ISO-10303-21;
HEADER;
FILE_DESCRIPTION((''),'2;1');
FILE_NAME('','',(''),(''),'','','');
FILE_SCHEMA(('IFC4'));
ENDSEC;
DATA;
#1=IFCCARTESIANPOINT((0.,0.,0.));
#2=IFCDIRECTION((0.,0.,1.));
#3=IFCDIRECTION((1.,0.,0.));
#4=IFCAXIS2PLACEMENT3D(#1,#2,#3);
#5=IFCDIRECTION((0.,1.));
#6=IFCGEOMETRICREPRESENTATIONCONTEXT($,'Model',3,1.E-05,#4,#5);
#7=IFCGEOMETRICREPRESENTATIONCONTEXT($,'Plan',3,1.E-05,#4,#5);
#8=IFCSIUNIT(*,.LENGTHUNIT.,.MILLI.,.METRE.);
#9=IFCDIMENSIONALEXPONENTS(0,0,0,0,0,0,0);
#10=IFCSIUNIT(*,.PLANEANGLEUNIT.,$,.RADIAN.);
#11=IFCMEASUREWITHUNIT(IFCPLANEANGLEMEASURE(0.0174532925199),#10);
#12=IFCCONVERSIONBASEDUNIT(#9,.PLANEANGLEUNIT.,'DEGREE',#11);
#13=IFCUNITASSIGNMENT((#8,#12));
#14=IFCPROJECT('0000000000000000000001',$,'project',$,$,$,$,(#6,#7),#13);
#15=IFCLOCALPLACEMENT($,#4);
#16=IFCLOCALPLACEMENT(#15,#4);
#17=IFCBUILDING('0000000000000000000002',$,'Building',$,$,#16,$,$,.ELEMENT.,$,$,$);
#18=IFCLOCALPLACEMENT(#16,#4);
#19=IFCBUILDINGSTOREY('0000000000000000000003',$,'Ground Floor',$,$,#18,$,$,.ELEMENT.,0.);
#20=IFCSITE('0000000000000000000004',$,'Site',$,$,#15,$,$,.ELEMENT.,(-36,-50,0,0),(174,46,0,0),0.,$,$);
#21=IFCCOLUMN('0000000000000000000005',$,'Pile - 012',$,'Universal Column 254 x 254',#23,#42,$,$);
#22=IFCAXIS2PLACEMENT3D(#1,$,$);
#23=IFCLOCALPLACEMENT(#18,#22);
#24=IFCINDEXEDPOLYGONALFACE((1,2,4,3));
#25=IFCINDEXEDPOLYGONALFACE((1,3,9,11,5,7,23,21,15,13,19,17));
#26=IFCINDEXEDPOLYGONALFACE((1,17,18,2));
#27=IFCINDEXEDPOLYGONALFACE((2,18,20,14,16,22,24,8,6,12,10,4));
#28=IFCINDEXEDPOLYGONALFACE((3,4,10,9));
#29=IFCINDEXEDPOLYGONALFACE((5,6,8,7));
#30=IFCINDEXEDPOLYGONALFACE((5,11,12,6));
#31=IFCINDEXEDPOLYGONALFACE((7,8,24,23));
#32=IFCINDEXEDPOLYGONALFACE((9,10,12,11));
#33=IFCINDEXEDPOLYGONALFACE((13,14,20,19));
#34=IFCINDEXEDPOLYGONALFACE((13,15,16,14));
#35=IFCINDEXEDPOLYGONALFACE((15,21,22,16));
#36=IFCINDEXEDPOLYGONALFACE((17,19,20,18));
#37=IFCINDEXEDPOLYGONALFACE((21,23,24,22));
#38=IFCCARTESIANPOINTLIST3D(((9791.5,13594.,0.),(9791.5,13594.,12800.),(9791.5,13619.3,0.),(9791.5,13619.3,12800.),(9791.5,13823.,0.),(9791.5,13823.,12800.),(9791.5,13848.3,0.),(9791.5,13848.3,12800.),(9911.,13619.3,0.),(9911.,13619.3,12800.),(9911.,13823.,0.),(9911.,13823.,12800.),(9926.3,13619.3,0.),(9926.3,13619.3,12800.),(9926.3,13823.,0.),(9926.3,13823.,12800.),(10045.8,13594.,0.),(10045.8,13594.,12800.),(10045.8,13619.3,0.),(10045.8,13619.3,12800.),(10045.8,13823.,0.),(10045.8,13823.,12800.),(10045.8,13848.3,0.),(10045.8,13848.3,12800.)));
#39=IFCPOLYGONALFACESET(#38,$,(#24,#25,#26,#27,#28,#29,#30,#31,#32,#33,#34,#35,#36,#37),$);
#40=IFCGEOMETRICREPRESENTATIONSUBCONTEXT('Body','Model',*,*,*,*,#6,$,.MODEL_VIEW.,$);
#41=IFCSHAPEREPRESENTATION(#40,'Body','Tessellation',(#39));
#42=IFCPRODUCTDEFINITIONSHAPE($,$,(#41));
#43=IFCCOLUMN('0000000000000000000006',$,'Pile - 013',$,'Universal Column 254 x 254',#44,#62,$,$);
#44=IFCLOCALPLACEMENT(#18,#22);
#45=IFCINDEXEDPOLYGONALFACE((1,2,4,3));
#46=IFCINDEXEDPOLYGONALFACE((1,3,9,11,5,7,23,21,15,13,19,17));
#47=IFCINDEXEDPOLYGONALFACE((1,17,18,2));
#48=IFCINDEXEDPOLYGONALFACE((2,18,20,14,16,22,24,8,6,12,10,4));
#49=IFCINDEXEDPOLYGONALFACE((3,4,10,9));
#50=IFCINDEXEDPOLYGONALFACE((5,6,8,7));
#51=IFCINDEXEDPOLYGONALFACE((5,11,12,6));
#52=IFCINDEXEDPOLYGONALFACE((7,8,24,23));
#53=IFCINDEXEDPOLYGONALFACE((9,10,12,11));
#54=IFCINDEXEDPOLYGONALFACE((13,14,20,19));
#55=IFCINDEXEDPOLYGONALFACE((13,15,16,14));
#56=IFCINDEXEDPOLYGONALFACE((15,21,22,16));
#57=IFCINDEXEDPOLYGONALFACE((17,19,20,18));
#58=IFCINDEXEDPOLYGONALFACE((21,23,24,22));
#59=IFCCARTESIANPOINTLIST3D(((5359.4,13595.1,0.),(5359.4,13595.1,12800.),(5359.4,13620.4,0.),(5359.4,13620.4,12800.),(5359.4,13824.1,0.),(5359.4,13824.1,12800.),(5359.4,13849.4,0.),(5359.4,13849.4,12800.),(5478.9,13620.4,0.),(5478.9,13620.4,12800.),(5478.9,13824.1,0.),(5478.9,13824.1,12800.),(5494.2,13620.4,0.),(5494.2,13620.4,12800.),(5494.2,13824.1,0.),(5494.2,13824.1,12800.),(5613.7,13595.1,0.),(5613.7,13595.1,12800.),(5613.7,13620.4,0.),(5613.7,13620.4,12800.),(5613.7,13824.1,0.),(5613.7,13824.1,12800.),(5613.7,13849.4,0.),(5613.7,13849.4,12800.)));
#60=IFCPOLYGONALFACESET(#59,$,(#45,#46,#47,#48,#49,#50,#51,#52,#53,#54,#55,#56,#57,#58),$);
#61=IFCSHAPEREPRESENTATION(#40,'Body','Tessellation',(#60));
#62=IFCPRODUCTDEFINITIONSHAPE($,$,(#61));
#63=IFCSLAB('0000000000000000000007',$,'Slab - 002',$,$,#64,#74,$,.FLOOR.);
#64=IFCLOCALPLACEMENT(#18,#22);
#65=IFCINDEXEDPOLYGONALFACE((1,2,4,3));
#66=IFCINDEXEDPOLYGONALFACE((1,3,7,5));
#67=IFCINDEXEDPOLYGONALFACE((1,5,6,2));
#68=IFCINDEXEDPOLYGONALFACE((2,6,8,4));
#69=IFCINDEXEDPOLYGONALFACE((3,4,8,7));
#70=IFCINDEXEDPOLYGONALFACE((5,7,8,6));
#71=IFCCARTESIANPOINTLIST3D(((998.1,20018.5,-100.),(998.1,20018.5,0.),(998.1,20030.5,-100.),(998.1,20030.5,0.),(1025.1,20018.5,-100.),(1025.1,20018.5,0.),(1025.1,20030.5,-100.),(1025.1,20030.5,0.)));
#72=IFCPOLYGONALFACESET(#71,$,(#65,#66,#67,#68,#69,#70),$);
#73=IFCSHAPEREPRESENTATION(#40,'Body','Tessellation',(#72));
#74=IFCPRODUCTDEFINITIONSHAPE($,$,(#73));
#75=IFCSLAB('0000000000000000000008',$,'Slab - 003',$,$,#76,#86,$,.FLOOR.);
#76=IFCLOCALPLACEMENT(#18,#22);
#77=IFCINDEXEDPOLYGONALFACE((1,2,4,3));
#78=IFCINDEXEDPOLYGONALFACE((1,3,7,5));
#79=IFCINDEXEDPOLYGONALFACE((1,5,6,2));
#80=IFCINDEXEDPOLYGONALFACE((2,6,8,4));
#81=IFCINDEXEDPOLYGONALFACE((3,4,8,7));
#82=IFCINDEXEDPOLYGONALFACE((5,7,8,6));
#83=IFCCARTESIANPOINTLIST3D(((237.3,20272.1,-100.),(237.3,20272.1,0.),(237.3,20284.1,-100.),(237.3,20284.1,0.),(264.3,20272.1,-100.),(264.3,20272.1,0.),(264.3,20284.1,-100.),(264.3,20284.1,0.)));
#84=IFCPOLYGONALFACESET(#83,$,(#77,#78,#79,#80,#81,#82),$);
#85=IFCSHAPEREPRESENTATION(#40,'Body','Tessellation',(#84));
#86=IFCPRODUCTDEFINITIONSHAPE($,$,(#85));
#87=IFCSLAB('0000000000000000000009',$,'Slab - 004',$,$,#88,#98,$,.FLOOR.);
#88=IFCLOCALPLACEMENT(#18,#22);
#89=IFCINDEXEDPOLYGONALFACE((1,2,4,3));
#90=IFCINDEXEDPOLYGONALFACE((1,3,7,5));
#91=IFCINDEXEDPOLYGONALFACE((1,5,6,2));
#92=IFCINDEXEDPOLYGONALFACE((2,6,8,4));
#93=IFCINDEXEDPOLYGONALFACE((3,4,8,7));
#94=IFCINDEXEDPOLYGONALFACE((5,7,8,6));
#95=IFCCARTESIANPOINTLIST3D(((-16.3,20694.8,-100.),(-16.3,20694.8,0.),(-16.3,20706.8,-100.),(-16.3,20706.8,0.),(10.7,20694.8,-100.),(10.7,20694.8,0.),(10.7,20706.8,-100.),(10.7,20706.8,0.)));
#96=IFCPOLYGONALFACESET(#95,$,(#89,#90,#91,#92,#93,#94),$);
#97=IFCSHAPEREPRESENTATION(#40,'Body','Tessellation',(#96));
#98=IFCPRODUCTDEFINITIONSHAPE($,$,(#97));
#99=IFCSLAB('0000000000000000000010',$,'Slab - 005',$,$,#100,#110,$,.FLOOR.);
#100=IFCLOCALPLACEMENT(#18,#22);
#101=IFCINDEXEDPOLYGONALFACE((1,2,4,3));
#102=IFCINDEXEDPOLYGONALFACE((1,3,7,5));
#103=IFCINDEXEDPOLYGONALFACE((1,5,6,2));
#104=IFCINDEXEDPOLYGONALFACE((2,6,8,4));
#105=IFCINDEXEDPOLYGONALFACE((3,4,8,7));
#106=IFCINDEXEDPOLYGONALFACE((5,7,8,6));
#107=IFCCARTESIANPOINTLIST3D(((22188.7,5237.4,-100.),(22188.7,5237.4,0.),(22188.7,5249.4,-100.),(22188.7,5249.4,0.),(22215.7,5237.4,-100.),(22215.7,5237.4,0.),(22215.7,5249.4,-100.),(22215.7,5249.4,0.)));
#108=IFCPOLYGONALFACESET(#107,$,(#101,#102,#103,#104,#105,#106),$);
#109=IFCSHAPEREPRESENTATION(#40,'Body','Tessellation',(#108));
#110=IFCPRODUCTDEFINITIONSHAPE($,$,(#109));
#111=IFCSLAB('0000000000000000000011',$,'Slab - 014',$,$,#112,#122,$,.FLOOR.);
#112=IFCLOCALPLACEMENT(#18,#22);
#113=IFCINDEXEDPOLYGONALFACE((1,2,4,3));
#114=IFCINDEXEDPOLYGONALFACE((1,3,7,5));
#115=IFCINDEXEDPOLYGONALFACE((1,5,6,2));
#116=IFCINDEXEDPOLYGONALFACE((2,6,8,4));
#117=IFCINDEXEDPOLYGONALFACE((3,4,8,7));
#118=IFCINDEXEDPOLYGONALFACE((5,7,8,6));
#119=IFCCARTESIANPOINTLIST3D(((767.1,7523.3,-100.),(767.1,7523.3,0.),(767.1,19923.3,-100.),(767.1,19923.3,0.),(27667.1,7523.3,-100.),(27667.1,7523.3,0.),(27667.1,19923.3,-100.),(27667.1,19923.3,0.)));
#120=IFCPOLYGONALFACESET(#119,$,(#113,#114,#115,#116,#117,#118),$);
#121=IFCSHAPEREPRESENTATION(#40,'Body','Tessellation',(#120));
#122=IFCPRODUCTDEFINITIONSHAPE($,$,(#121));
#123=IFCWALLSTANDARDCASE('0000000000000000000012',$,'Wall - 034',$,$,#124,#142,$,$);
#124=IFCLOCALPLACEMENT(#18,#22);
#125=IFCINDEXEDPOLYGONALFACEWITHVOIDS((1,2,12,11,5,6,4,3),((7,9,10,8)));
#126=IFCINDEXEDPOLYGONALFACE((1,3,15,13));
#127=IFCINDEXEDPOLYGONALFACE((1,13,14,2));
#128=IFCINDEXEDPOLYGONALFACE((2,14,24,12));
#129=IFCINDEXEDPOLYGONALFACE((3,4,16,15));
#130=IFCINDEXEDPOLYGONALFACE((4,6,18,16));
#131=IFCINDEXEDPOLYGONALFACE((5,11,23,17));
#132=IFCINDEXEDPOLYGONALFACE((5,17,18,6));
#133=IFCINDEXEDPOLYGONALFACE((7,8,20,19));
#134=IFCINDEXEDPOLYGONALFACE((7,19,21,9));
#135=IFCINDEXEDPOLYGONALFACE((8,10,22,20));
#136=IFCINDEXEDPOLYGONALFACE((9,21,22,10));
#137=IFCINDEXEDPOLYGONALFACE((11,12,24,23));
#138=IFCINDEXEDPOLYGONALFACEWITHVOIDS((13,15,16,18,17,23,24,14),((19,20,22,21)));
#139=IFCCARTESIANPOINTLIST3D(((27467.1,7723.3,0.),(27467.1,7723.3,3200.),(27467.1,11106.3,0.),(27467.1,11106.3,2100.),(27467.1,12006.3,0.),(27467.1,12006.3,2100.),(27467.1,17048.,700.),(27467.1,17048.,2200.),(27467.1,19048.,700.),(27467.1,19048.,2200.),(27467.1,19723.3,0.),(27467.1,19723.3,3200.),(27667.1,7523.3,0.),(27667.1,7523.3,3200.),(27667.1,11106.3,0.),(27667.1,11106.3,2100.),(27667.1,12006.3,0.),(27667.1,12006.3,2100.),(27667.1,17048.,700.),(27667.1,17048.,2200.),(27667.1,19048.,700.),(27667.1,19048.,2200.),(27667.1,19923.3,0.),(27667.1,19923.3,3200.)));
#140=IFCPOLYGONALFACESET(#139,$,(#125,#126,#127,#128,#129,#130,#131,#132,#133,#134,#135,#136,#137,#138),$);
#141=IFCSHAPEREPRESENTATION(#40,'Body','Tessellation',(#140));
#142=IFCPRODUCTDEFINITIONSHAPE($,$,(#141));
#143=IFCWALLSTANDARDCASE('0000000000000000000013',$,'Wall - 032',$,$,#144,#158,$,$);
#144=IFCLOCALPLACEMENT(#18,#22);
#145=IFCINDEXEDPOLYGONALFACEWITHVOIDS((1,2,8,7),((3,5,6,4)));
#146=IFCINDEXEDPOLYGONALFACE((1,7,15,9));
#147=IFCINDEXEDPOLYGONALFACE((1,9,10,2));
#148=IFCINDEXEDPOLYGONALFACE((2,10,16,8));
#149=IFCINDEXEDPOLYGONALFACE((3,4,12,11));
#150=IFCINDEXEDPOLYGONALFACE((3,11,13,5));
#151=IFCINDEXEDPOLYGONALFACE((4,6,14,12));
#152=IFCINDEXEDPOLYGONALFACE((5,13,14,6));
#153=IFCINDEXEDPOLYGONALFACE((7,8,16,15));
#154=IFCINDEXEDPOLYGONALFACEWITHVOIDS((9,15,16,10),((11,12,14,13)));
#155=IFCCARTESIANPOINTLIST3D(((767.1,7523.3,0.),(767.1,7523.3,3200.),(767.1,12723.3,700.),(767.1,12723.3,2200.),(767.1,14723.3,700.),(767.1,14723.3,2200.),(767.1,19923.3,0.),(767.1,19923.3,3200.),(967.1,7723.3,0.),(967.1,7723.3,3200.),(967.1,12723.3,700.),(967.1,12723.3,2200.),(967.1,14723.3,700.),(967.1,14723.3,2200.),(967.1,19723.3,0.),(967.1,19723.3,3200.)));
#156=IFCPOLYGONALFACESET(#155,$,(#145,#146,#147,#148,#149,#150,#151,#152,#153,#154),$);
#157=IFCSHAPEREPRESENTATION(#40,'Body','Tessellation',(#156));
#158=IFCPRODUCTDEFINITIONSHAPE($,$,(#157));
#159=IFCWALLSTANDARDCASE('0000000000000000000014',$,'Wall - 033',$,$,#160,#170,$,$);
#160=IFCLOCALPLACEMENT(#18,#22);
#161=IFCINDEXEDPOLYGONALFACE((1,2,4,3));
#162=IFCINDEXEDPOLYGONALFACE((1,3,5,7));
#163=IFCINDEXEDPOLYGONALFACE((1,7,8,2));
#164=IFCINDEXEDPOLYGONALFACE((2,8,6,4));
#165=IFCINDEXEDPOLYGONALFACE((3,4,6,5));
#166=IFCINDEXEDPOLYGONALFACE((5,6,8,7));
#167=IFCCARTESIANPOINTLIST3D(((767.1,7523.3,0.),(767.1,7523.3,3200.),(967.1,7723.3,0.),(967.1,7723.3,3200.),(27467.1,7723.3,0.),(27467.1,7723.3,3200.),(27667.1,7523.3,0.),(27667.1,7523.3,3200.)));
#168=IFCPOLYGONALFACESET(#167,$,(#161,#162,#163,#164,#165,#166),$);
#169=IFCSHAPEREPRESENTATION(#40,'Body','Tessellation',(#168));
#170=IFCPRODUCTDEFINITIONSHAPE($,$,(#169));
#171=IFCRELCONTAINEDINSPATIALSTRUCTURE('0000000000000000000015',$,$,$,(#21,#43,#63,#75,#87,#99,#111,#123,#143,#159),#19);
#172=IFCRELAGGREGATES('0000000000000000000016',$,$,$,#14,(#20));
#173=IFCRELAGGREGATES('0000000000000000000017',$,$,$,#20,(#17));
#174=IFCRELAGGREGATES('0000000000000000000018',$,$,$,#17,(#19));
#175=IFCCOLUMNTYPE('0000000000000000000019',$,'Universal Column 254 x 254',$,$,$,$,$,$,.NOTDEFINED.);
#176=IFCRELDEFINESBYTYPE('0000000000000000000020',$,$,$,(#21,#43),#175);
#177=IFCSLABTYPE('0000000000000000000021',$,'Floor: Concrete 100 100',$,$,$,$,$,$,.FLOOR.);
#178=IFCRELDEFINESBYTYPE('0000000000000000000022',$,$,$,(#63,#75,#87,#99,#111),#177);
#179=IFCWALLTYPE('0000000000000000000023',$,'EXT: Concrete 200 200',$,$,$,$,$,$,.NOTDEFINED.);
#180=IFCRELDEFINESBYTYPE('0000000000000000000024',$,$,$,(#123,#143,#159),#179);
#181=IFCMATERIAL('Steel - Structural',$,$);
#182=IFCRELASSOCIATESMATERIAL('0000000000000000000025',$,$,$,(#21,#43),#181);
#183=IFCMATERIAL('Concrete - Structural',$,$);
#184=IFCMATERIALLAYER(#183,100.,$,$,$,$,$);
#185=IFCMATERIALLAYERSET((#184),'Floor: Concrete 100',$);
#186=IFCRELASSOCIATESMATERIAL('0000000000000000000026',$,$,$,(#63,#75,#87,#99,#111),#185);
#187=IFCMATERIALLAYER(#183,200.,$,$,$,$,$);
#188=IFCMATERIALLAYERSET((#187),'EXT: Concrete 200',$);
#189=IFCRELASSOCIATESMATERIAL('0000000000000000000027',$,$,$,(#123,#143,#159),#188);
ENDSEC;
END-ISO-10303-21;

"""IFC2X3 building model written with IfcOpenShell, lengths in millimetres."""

from ifc_helpers import new_model, entity, si_unit, converted_unit, direction, frame, origin_with_axes, origin_2d_with_axis, place, context, subcontext, project, spatial, polyline, rectangle, outline, extrude, material, layer, layer_set, layer_usage, type_object, element, save


model = new_model("IFC2X3")

# Units and contexts
model_context = context("Model", 3, precision=1e-05, world=origin_with_axes(), true_north=direction((0.0, 1.0)))
plan_context = context("Plan", 3, precision=1e-05, world=origin_with_axes(), true_north=direction((0.0, 1.0)))
body_context = subcontext(model_context, "Body", "Model", "MODEL_VIEW")
ifc_project = project(units=[si_unit("LENGTHUNIT", "METRE", prefix="MILLI"), converted_unit("PLANEANGLEUNIT", "DEGREE", entity("IfcPlaneAngleMeasure", 0.0174532925199), si_unit("PLANEANGLEUNIT", "RADIAN"), dimensions=[0, 0, 0, 0, 0, 0, 0])], contexts=[model_context, plan_context])

# Site, building, storey
site_placement = place(None, origin_with_axes())
site = spatial("IfcSite", under=ifc_project, at=site_placement, Name="Site", CompositionType="ELEMENT", RefLatitude=(-36, -50, 0, 0), RefLongitude=(174, 46, 0, 0), RefElevation=0.0)
building_placement = place(site_placement, origin_with_axes())
building = spatial("IfcBuilding", under=site, at=building_placement, Name="Building", CompositionType="ELEMENT")
storey_placement = place(building_placement, origin_with_axes())
storey = spatial("IfcBuildingStorey", under=building, at=storey_placement, Name="Ground Floor", CompositionType="ELEMENT", Elevation=0.0)

# Columns
ifc_material_1 = material(Name="Steel - Structural")
column_type = type_object("IfcColumnType", Name="Universal Column 254 x 254", PredefinedType="NOTDEFINED")
for number, where, z_axis, x_axis, name in (
    (1, (9918.6, 13721.1, 0.0), (0.0, 0.0, 1.0), (1.0, 0.0, 0.0), "Pile - 012"),
    (2, (5486.6, 13722.3, 0.0), (0.0, 0.0, 1.0), (1.0, 0.0, 0.0), "Pile - 013"),
):
    element("IfcColumn", number, at=place(storey_placement, frame(where, z_axis=z_axis, x_axis=x_axis)), inside=storey, type_object=column_type, material=ifc_material_1, Name=name, ObjectType="Universal Column 254 x 254", context=body_context, shape_type="SweptSolid", body=[
        extrude(outline(polyline([(-127.2, -127.2), (127.2, -127.2), (127.2, -101.8), (7.7, -101.8), (7.7, 101.8), (127.2, 101.8), (127.2, 127.2), (-127.2, 127.2), (-127.2, 101.8), (-7.7, 101.8), (-7.7, -101.8), (-127.2, -101.8), (-127.2, -127.2)])), origin_with_axes(), (0.0, 0.0, 1.0), 12800.0),
    ])

# Slabs
ifc_material_2 = material(Name="Concrete - Structural")
ifc_layer_1 = layer(ifc_material_2, 100.0)
ifc_layer_set_1 = layer_set([ifc_layer_1], Name="Floor: Concrete 100")
ifc_layer_usage_1 = layer_usage(ifc_layer_set_1, "AXIS3", "NEGATIVE", 100.0)
slab_type = type_object("IfcSlabType", Name="Floor: Concrete 100 100", PredefinedType="FLOOR")
slab_1_placement = place(storey_placement, frame((998.1, 20030.5, 0.0), z_axis=(0.0, 0.0, 1.0), x_axis=(1.0, 0.0, 0.0)))
element("IfcSlab", 3, at=slab_1_placement, inside=storey, type_object=slab_type, material=ifc_layer_usage_1, Name="Slab - 002", PredefinedType="FLOOR", context=body_context, shape_type="SweptSolid", body=[
    extrude(outline(polyline([(0.0, 0.0), (0.0, -12.0), (27.0, -12.0), (27.0, 0.0), (0.0, 0.0)])), frame((0.0, 0.0, -100.0), z_axis=(0.0, 0.0, 1.0), x_axis=(1.0, 0.0, 0.0)), (0.0, 0.0, 1.0), 100.0),
])
ifc_layer_usage_2 = layer_usage(ifc_layer_set_1, "AXIS3", "NEGATIVE", 100.0)
slab_2_placement = place(storey_placement, frame((237.3, 20284.1, 0.0), z_axis=(0.0, 0.0, 1.0), x_axis=(1.0, 0.0, 0.0)))
element("IfcSlab", 4, at=slab_2_placement, inside=storey, type_object=slab_type, material=ifc_layer_usage_2, Name="Slab - 003", PredefinedType="FLOOR", context=body_context, shape_type="SweptSolid", body=[
    extrude(outline(polyline([(0.0, 0.0), (0.0, -12.0), (27.0, -12.0), (27.0, 0.0), (0.0, 0.0)])), frame((0.0, 0.0, -100.0), z_axis=(0.0, 0.0, 1.0), x_axis=(1.0, 0.0, 0.0)), (0.0, 0.0, 1.0), 100.0),
])
ifc_layer_usage_3 = layer_usage(ifc_layer_set_1, "AXIS3", "NEGATIVE", 100.0)
slab_3_placement = place(storey_placement, frame((-16.3, 20706.8, 0.0), z_axis=(0.0, 0.0, 1.0), x_axis=(1.0, 0.0, 0.0)))
element("IfcSlab", 5, at=slab_3_placement, inside=storey, type_object=slab_type, material=ifc_layer_usage_3, Name="Slab - 004", PredefinedType="FLOOR", context=body_context, shape_type="SweptSolid", body=[
    extrude(outline(polyline([(0.0, 0.0), (0.0, -12.0), (27.0, -12.0), (27.0, 0.0), (0.0, 0.0)])), frame((0.0, 0.0, -100.0), z_axis=(0.0, 0.0, 1.0), x_axis=(1.0, 0.0, 0.0)), (0.0, 0.0, 1.0), 100.0),
])
ifc_layer_usage_4 = layer_usage(ifc_layer_set_1, "AXIS3", "NEGATIVE", 100.0)
slab_4_placement = place(storey_placement, frame((22215.7, 5237.4, 0.0), z_axis=(0.0, 0.0, 1.0), x_axis=(1.0, 0.0, 0.0)))
element("IfcSlab", 6, at=slab_4_placement, inside=storey, type_object=slab_type, material=ifc_layer_usage_4, Name="Slab - 005", PredefinedType="FLOOR", context=body_context, shape_type="SweptSolid", body=[
    extrude(outline(polyline([(0.0, 0.0), (0.0, 12.0), (-27.0, 12.0), (-27.0, 0.0), (0.0, 0.0)])), frame((0.0, 0.0, -100.0), z_axis=(0.0, 0.0, 1.0), x_axis=(1.0, 0.0, 0.0)), (0.0, 0.0, 1.0), 100.0),
])
ifc_layer_usage_5 = layer_usage(ifc_layer_set_1, "AXIS3", "NEGATIVE", 100.0)
slab_5_placement = place(storey_placement, frame((27667.1, 7523.3, 0.0), z_axis=(0.0, 0.0, 1.0), x_axis=(1.0, 0.0, 0.0)))
element("IfcSlab", 7, at=slab_5_placement, inside=storey, type_object=slab_type, material=ifc_layer_usage_5, Name="Slab - 014", PredefinedType="FLOOR", context=body_context, shape_type="SweptSolid", body=[
    extrude(outline(polyline([(0.0, 0.0), (0.0, 12400.0), (-26900.0, 12400.0), (-26900.0, 0.0), (0.0, 0.0)])), frame((0.0, 0.0, -100.0), z_axis=(0.0, 0.0, 1.0), x_axis=(1.0, 0.0, 0.0)), (0.0, 0.0, 1.0), 100.0),
])

# Wall, openings
ifc_layer_2 = layer(ifc_material_2, 200.0)
ifc_layer_set_2 = layer_set([ifc_layer_2], Name="EXT: Concrete 200")
ifc_layer_usage_6 = layer_usage(ifc_layer_set_2, "AXIS2", "POSITIVE", 0.0)
wall_type_1 = type_object("IfcWallType", Name="EXT: Concrete 200 200", PredefinedType="NOTDEFINED")
wall_1_placement = place(storey_placement, frame((27667.1, 7523.3, 0.0), z_axis=(0.0, 0.0, 1.0), x_axis=(0.0, 1.0, 0.0)))
wall_1 = element("IfcWallStandardCase", 8, at=wall_1_placement, inside=storey, type_object=wall_type_1, material=ifc_layer_usage_6, Name="Wall - 034", context=body_context, shape_type="SweptSolid", body=[
    extrude(outline(polyline([(0.0, 0.0), (12400.0, 0.0), (12200.0, 200.0), (200.0, 200.0), (0.0, 0.0)])), origin_with_axes(), (0.0, 0.0, 1.0), 3200.0),
])
opening_1_placement = place(wall_1_placement, frame((10524.7, 0.0, 700.0), z_axis=(0.0, 0.0, 1.0), x_axis=(1.0, 0.0, 0.0)))
element("IfcOpeningElement", 9, at=opening_1_placement, cuts=wall_1, context=body_context, shape_type="SweptSolid", body=[
    extrude(rectangle(XDim=2000.0, YDim=1500.0, at=origin_2d_with_axis()), frame((0.0, 200.0, 750.0), z_axis=(0.0, 1.0, 0.0), x_axis=(1.0, 0.0, 0.0)), (0.0, 0.0, -1.0), 600.0),
])
opening_2_placement = place(wall_1_placement, frame((4033.0, 0.0, 0.0), z_axis=(0.0, 0.0, 1.0), x_axis=(1.0, 0.0, 0.0)))
element("IfcOpeningElement", 10, at=opening_2_placement, cuts=wall_1, context=body_context, shape_type="SweptSolid", body=[
    extrude(rectangle(XDim=900.0, YDim=2100.0, at=origin_2d_with_axis()), frame((0.0, -200.0, 1050.0), z_axis=(0.0, 1.0, 0.0), x_axis=(-1.0, 0.0, 0.0)), (0.0, 0.0, 1.0), 600.0),
])

# Wall, opening
ifc_layer_usage_7 = layer_usage(ifc_layer_set_2, "AXIS2", "POSITIVE", 0.0)
wall_2_placement = place(storey_placement, frame((767.1, 19923.3, 0.0), z_axis=(0.0, 0.0, 1.0), x_axis=(0.0, -1.0, 0.0)))
wall_2 = element("IfcWallStandardCase", 11, at=wall_2_placement, inside=storey, type_object=wall_type_1, material=ifc_layer_usage_7, Name="Wall - 032", context=body_context, shape_type="SweptSolid", body=[
    extrude(outline(polyline([(0.0, 0.0), (12400.0, 0.0), (12200.0, 200.0), (200.0, 200.0), (0.0, 0.0)])), origin_with_axes(), (0.0, 0.0, 1.0), 3200.0),
])
opening_3_placement = place(wall_2_placement, frame((6200.0, 0.0, 700.0), z_axis=(0.0, 0.0, 1.0), x_axis=(1.0, 0.0, 0.0)))
element("IfcOpeningElement", 12, at=opening_3_placement, cuts=wall_2, context=body_context, shape_type="SweptSolid", body=[
    extrude(rectangle(XDim=2000.0, YDim=1500.0, at=origin_2d_with_axis()), frame((0.0, 200.0, 750.0), z_axis=(0.0, 1.0, 0.0), x_axis=(1.0, 0.0, 0.0)), (0.0, 0.0, -1.0), 600.0),
])

# Wall
ifc_layer_usage_8 = layer_usage(ifc_layer_set_2, "AXIS2", "POSITIVE", 0.0)
wall_3_placement = place(storey_placement, frame((767.1, 7523.3, 0.0), z_axis=(0.0, 0.0, 1.0), x_axis=(1.0, 0.0, 0.0)))
element("IfcWallStandardCase", 13, at=wall_3_placement, inside=storey, type_object=wall_type_1, material=ifc_layer_usage_8, Name="Wall - 033", context=body_context, shape_type="SweptSolid", body=[
    extrude(outline(polyline([(0.0, 0.0), (26900.0, 0.0), (26700.0, 200.0), (200.0, 200.0), (0.0, 0.0)])), origin_with_axes(), (0.0, 0.0, 1.0), 3200.0),
])

save(model, "model.ifc")
